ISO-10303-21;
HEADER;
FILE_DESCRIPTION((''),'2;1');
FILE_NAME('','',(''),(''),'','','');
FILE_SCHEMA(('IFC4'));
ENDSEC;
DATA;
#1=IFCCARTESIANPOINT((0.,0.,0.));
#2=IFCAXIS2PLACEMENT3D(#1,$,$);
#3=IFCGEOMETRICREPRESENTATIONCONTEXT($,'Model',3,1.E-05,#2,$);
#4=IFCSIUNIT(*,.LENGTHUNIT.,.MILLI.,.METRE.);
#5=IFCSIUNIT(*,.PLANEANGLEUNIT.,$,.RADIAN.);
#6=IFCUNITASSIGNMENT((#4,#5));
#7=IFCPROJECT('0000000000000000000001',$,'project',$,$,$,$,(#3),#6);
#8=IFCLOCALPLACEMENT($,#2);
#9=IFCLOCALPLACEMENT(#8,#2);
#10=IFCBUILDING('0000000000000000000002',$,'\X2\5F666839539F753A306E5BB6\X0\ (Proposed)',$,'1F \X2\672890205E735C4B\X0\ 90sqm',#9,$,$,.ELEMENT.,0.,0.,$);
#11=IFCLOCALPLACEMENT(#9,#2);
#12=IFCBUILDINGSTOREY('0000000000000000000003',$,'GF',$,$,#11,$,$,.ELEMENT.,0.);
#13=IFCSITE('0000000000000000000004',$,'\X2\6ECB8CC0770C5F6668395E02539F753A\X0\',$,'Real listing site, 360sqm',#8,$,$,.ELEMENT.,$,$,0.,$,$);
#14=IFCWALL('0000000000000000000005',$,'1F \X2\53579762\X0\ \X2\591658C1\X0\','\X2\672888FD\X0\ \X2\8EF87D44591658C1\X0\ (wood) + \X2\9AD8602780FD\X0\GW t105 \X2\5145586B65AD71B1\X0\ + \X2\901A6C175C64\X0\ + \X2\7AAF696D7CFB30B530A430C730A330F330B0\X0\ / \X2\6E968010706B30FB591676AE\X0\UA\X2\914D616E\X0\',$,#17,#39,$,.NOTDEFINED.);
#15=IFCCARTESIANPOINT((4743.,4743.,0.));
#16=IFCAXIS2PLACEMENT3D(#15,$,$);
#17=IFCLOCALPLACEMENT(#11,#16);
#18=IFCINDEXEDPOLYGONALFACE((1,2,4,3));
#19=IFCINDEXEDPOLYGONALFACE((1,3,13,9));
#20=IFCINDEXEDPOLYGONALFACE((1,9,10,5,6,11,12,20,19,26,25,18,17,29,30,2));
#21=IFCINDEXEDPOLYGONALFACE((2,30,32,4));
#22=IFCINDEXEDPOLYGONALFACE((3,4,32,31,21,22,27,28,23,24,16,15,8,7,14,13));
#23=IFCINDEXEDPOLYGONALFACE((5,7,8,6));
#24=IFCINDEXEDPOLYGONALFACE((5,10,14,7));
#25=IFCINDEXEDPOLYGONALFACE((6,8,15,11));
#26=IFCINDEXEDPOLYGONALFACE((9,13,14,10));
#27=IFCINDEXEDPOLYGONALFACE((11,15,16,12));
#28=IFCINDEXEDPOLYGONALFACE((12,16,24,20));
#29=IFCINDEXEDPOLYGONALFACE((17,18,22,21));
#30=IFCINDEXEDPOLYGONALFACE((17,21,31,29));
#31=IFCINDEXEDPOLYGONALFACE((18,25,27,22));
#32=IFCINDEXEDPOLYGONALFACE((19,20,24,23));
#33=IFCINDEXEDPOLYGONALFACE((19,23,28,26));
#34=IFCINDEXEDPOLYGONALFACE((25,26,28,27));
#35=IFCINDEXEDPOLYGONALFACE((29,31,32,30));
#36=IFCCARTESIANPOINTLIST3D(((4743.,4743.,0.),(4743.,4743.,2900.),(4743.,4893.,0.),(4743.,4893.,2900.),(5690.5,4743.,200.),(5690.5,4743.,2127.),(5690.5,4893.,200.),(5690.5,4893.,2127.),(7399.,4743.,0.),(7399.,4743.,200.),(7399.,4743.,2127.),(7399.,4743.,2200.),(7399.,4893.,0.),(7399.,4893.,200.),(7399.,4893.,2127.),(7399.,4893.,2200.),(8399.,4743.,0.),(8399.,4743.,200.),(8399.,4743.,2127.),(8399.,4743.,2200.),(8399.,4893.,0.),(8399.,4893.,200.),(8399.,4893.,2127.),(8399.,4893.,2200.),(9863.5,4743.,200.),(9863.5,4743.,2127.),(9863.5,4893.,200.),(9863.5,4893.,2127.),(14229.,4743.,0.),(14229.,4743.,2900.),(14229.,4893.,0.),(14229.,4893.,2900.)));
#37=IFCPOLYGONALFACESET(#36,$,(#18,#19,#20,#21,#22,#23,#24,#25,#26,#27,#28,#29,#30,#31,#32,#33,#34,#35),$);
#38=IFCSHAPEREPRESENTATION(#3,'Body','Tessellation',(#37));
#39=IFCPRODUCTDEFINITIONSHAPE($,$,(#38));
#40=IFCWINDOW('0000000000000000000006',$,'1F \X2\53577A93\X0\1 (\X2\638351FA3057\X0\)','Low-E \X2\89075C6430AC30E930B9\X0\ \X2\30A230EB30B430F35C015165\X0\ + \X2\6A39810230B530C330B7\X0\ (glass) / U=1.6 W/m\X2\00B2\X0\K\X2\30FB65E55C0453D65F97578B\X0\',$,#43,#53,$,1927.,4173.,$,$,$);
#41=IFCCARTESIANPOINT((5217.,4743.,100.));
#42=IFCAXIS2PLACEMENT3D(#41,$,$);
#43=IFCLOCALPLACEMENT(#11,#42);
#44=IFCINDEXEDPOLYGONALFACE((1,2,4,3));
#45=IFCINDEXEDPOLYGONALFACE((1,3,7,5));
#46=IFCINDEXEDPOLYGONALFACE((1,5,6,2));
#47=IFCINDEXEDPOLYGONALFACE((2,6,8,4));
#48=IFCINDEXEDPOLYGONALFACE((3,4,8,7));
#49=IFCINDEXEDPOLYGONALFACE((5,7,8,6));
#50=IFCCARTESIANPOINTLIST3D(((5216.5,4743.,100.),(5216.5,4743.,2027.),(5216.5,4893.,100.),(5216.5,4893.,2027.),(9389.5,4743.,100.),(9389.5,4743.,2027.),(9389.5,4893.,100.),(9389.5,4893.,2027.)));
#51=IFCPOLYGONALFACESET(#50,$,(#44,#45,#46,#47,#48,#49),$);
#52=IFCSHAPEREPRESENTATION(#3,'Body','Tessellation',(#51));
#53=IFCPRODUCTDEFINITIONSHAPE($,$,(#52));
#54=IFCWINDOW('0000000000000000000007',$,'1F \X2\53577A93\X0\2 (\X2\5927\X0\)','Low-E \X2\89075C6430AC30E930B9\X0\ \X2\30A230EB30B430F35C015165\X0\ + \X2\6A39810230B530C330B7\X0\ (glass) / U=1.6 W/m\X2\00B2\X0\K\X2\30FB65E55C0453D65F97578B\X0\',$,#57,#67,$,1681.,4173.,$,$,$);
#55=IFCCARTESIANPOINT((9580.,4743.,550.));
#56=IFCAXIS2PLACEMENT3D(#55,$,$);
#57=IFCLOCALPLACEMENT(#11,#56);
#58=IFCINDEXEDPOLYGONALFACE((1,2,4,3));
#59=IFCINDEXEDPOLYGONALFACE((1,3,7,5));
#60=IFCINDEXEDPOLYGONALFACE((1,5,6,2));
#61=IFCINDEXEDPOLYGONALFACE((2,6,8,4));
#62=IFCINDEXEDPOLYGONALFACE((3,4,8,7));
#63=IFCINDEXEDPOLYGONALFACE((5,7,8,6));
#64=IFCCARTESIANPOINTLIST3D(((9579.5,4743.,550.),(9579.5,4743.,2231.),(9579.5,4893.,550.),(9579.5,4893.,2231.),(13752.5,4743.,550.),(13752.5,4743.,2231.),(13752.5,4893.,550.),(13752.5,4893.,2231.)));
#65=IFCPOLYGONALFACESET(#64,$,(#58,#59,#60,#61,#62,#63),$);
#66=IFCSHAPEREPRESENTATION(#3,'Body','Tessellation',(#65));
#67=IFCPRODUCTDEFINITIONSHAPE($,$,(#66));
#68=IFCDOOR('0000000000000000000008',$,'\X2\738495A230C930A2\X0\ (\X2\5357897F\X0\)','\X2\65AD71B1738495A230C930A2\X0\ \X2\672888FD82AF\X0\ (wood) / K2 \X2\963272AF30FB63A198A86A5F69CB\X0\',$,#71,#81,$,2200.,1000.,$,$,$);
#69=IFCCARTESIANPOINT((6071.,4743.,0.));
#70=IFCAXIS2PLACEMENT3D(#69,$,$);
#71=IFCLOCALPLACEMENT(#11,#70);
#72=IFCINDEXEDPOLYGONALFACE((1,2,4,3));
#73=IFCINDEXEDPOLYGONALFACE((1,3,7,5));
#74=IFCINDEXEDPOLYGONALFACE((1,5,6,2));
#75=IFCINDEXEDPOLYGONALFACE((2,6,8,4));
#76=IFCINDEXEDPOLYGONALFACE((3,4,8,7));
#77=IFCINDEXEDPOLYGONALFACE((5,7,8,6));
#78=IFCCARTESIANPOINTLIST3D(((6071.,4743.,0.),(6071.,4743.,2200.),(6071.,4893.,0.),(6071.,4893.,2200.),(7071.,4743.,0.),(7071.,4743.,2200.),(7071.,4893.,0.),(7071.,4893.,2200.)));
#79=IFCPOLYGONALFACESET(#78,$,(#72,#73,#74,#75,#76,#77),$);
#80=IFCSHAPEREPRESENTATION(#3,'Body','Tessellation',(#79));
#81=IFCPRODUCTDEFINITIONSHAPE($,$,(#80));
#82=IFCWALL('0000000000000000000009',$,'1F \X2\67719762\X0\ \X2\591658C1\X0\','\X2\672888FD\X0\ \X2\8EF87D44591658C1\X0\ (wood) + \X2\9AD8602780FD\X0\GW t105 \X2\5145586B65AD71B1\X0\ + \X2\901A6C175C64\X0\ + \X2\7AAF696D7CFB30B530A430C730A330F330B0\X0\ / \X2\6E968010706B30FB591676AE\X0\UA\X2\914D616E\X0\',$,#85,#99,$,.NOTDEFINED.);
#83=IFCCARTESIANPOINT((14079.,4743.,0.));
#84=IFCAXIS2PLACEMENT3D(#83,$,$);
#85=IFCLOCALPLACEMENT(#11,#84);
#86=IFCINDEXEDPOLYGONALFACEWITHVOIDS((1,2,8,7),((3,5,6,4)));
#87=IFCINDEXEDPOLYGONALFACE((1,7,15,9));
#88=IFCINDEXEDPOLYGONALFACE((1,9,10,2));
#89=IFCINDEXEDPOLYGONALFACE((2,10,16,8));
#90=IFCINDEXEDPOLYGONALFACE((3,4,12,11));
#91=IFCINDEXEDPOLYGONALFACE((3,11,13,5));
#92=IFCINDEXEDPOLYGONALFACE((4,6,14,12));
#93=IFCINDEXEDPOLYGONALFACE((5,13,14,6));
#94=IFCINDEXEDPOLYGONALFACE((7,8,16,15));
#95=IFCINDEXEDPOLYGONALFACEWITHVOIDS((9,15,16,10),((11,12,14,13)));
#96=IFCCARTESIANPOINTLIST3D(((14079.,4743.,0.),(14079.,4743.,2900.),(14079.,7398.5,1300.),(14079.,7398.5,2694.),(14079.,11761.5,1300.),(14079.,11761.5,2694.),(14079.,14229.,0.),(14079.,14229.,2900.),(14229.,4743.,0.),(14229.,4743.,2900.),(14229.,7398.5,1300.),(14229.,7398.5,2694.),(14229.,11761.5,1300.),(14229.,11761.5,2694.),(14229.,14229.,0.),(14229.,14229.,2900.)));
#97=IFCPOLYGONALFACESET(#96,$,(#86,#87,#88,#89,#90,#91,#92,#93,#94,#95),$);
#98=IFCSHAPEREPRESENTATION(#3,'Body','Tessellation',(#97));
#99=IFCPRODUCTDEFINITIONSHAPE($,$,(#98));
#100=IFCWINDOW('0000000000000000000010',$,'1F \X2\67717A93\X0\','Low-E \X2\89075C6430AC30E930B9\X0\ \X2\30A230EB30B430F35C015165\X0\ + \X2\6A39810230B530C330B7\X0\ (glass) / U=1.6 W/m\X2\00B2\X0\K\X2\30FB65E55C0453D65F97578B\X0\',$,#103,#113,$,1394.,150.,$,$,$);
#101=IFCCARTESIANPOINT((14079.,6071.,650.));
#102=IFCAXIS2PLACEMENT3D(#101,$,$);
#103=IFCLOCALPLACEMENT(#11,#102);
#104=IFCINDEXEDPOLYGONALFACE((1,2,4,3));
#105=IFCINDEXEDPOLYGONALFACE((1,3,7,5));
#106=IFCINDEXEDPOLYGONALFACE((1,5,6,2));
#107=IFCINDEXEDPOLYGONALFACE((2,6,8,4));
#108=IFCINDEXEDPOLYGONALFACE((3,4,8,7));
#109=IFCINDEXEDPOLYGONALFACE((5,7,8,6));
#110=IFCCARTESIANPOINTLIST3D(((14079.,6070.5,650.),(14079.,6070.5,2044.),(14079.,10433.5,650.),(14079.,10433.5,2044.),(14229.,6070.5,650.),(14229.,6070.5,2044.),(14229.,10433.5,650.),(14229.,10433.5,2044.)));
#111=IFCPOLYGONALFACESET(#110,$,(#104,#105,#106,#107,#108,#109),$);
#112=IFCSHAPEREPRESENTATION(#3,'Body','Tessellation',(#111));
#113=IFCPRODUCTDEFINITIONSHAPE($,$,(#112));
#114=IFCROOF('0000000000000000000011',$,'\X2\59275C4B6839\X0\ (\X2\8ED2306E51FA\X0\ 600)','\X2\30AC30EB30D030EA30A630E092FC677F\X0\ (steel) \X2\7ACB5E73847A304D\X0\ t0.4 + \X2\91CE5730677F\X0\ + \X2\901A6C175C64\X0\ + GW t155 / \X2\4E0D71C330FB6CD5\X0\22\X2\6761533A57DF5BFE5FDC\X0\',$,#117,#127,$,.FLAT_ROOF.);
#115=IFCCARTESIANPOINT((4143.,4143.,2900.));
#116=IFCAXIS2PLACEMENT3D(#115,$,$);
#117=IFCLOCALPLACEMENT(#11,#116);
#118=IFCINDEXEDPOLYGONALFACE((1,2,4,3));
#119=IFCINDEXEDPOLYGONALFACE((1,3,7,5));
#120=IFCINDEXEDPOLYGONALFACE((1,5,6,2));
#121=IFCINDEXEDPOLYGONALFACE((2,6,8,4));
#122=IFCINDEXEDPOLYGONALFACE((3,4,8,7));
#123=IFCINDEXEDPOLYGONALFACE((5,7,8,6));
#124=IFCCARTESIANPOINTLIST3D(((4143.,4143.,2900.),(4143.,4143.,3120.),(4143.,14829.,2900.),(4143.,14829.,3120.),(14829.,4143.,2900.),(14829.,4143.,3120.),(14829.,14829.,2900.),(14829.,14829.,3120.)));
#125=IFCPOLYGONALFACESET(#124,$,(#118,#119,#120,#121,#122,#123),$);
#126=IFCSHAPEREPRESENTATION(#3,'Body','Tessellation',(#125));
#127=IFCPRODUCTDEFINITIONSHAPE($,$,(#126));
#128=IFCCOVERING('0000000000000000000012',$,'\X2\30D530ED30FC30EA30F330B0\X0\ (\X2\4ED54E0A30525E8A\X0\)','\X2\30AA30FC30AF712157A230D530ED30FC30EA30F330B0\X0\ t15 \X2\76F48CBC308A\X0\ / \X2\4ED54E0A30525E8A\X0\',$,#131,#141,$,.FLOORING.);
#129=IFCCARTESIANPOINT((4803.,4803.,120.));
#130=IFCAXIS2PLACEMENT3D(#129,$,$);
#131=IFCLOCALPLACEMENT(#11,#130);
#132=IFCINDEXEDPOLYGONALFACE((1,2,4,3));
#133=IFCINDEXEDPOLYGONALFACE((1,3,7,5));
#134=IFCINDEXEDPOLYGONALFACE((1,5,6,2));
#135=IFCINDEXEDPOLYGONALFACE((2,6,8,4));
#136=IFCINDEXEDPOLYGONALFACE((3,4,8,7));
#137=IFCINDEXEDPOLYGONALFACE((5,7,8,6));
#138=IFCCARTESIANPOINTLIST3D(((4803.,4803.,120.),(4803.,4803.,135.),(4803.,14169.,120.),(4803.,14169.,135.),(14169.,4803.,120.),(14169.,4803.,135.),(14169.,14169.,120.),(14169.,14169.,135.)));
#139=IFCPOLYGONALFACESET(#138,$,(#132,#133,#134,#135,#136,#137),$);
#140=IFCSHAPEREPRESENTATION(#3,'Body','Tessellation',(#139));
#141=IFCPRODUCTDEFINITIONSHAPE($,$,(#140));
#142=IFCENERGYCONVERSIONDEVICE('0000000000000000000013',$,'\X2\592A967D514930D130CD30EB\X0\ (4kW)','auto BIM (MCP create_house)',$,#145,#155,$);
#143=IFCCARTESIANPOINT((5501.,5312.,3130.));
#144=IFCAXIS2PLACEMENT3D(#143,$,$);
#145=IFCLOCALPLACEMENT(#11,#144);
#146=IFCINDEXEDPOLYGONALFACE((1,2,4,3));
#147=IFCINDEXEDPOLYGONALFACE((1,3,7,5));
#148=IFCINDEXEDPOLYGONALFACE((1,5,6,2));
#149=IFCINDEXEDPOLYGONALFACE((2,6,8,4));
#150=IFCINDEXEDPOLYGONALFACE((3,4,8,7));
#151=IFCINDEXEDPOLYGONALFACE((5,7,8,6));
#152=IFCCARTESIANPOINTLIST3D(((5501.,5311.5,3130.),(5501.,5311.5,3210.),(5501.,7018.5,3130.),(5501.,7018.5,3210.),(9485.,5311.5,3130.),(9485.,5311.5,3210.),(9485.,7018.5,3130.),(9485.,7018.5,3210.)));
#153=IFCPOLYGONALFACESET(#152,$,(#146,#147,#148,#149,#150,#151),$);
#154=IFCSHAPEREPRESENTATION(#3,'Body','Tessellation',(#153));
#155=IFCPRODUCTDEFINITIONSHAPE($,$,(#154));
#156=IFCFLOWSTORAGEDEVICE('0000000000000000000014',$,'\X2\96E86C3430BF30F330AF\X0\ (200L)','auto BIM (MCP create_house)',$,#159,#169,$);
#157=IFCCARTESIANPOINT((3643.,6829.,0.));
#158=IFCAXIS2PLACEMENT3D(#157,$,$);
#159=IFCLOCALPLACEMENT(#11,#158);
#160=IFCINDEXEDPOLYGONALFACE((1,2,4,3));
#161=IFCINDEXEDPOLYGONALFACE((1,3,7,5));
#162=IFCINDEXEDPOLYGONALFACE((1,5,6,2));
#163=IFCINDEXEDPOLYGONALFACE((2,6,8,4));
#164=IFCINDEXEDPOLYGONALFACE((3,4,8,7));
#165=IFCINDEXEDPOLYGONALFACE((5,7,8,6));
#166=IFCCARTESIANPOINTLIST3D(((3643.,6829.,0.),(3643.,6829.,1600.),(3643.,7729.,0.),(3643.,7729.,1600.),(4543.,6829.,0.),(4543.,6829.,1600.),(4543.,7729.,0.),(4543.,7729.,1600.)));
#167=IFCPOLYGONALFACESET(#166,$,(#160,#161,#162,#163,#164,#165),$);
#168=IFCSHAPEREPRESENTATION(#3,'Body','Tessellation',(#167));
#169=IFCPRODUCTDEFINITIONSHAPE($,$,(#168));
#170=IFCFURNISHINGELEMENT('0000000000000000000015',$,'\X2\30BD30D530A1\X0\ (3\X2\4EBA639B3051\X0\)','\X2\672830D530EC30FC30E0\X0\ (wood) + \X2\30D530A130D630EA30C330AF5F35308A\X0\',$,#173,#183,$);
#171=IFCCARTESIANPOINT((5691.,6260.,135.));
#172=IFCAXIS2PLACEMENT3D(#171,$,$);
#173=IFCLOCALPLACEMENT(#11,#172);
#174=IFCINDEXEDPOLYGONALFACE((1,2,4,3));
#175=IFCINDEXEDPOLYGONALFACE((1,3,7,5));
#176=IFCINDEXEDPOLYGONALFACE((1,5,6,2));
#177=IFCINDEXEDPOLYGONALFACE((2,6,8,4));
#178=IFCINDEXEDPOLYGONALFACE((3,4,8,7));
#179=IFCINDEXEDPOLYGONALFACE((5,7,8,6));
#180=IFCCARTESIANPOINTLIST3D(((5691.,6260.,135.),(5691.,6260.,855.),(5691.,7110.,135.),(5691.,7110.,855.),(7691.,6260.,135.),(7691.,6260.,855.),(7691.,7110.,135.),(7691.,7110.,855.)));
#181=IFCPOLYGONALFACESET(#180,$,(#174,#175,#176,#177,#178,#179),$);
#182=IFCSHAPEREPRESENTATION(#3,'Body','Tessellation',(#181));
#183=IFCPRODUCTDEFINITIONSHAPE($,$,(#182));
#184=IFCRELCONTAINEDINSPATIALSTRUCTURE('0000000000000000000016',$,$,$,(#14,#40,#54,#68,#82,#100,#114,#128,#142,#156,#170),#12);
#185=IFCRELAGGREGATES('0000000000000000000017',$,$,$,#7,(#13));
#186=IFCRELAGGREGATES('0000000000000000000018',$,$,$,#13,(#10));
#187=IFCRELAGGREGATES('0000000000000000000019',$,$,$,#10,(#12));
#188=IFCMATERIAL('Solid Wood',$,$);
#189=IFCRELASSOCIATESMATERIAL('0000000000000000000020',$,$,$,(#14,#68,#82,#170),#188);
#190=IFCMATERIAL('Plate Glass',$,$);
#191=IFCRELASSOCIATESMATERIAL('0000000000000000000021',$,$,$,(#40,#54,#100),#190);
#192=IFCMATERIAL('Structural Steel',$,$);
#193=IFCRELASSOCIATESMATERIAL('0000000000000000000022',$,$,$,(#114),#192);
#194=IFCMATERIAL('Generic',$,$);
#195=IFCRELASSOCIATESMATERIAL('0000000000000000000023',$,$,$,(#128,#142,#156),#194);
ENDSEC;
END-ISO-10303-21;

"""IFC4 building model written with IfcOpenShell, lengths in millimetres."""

from ifc_helpers import new_model, si_unit, frame, frame_2d, origin, place, context, project, spatial, rectangle, extrude, material, element, fill, save


model = new_model("IFC4")

# Units and contexts
model_context = context("Model", 3, precision=1e-05, world=origin())
ifc_project = project(units=[si_unit("LENGTHUNIT", "METRE", prefix="MILLI"), si_unit("PLANEANGLEUNIT", "RADIAN")], contexts=[model_context])

# Site, building, storey
site_placement = place(None, origin())
site = spatial("IfcSite", under=ifc_project, at=site_placement, Name="滋賀県彦根市原町", ObjectType="Real listing site, 360sqm", CompositionType="ELEMENT", RefElevation=0.0)
building_placement = place(site_placement, origin())
building = spatial("IfcBuilding", under=site, at=building_placement, Name="彦根原町の家 (Proposed)", ObjectType="1F 木造平屋 90sqm", CompositionType="ELEMENT", ElevationOfRefHeight=0.0, ElevationOfTerrain=0.0)
storey_placement = place(building_placement, origin())
storey = spatial("IfcBuildingStorey", under=building, at=storey_placement, Name="GF", CompositionType="ELEMENT", Elevation=0.0)

# Shared definitions
ifc_material_1 = material(Name="Solid Wood")

# Wall, openings, windows, door
wall_1_placement = place(storey_placement, frame((4743.0, 4743.0, 0.0)))
wall_1 = element("IfcWall", 1, at=wall_1_placement, inside=storey, material=ifc_material_1, Name="1F 南面 外壁", Description="木製 軸組外壁 (wood) + 高性能GW t105 充填断熱 + 通気層 + 窯業系サイディング / 準耐火・外皮UA配慮", PredefinedType="NOTDEFINED", context=model_context, shape_type="SweptSolid", body=[
    extrude(rectangle(XDim=9486.0, YDim=150.0, at=frame_2d((4743.0, 75.0))), frame((4743.0, 4743.0, 0.0)), (0.0, 0.0, 1.0), 2900.0),
])
opening_1_placement = place(storey_placement, frame((5217.0, 4743.0, 100.0)))
opening_1 = element("IfcOpeningElement", 2, at=opening_1_placement, cuts=wall_1, PredefinedType="NOTDEFINED", context=model_context, shape_type="SweptSolid", body=[
    extrude(rectangle(XDim=4173.0, YDim=150.0, at=frame_2d((2086.0, 75.0))), frame((5217.0, 4743.0, 100.0)), (0.0, 0.0, 1.0), 1927.0),
])
opening_2_placement = place(storey_placement, frame((9580.0, 4743.0, 550.0)))
opening_2 = element("IfcOpeningElement", 3, at=opening_2_placement, cuts=wall_1, PredefinedType="NOTDEFINED", context=model_context, shape_type="SweptSolid", body=[
    extrude(rectangle(XDim=4173.0, YDim=150.0, at=frame_2d((2086.0, 75.0))), frame((9580.0, 4743.0, 550.0)), (0.0, 0.0, 1.0), 1681.0),
])
opening_3_placement = place(storey_placement, frame((6071.0, 4743.0, 0.0)))
opening_3 = element("IfcOpeningElement", 4, at=opening_3_placement, cuts=wall_1, PredefinedType="NOTDEFINED", context=model_context, shape_type="SweptSolid", body=[
    extrude(rectangle(XDim=1000.0, YDim=150.0, at=frame_2d((500.0, 75.0))), frame((6071.0, 4743.0, 0.0)), (0.0, 0.0, 1.0), 2200.0),
])
ifc_material_2 = material(Name="Plate Glass")
window_1_placement = place(storey_placement, frame((5217.0, 4743.0, 100.0)))
window_1 = element("IfcWindow", 5, at=window_1_placement, inside=storey, material=ifc_material_2, Name="1F 南窓1 (掃出し)", Description="Low-E 複層ガラス アルゴン封入 + 樹脂サッシ (glass) / U=1.6 W/m²K・日射取得型", OverallHeight=1927.0, OverallWidth=4173.0, context=model_context, shape_type="SweptSolid", body=[
    extrude(rectangle(XDim=4173.0, YDim=150.0, at=frame_2d((2086.0, 75.0))), frame((5217.0, 4743.0, 100.0)), (0.0, 0.0, 1.0), 1927.0),
])
fill(opening_1, window_1)
window_2_placement = place(storey_placement, frame((9580.0, 4743.0, 550.0)))
window_2 = element("IfcWindow", 6, at=window_2_placement, inside=storey, material=ifc_material_2, Name="1F 南窓2 (大)", Description="Low-E 複層ガラス アルゴン封入 + 樹脂サッシ (glass) / U=1.6 W/m²K・日射取得型", OverallHeight=1681.0, OverallWidth=4173.0, context=model_context, shape_type="SweptSolid", body=[
    extrude(rectangle(XDim=4173.0, YDim=150.0, at=frame_2d((2086.0, 75.0))), frame((9580.0, 4743.0, 550.0)), (0.0, 0.0, 1.0), 1681.0),
])
fill(opening_2, window_2)
door_placement = place(storey_placement, frame((6071.0, 4743.0, 0.0)))
door = element("IfcDoor", 7, at=door_placement, inside=storey, material=ifc_material_1, Name="玄関ドア (南西)", Description="断熱玄関ドア 木製芯 (wood) / K2 防犯・採風機構", OverallHeight=2200.0, OverallWidth=1000.0, context=model_context, shape_type="SweptSolid", body=[
    extrude(rectangle(XDim=1000.0, YDim=150.0, at=frame_2d((500.0, 75.0))), frame((6071.0, 4743.0, 0.0)), (0.0, 0.0, 1.0), 2200.0),
])
fill(opening_3, door)

# Wall, opening, window
wall_2_placement = place(storey_placement, frame((14079.0, 4743.0, 0.0)))
wall_2 = element("IfcWall", 8, at=wall_2_placement, inside=storey, material=ifc_material_1, Name="1F 東面 外壁", Description="木製 軸組外壁 (wood) + 高性能GW t105 充填断熱 + 通気層 + 窯業系サイディング / 準耐火・外皮UA配慮", PredefinedType="NOTDEFINED", context=model_context, shape_type="SweptSolid", body=[
    extrude(rectangle(XDim=150.0, YDim=9486.0, at=frame_2d((75.0, 4743.0))), frame((14079.0, 4743.0, 0.0)), (0.0, 0.0, 1.0), 2900.0),
])
opening_4_placement = place(storey_placement, frame((14079.0, 6071.0, 650.0)))
opening_4 = element("IfcOpeningElement", 9, at=opening_4_placement, cuts=wall_2, PredefinedType="NOTDEFINED", context=model_context, shape_type="SweptSolid", body=[
    extrude(rectangle(XDim=150.0, YDim=4363.0, at=frame_2d((75.0, 2181.0))), frame((14079.0, 6071.0, 650.0)), (0.0, 0.0, 1.0), 1394.0),
])
window_3_placement = place(storey_placement, frame((14079.0, 6071.0, 650.0)))
window_3 = element("IfcWindow", 10, at=window_3_placement, inside=storey, material=ifc_material_2, Name="1F 東窓", Description="Low-E 複層ガラス アルゴン封入 + 樹脂サッシ (glass) / U=1.6 W/m²K・日射取得型", OverallHeight=1394.0, OverallWidth=150.0, context=model_context, shape_type="SweptSolid", body=[
    extrude(rectangle(XDim=150.0, YDim=4363.0, at=frame_2d((75.0, 2181.0))), frame((14079.0, 6071.0, 650.0)), (0.0, 0.0, 1.0), 1394.0),
])
fill(opening_4, window_3)

# Roof
ifc_material_3 = material(Name="Structural Steel")
roof_placement = place(storey_placement, frame((4143.0, 4143.0, 2900.0)))
element("IfcRoof", 11, at=roof_placement, inside=storey, material=ifc_material_3, Name="大屋根 (軒の出 600)", Description="ガルバリウム鋼板 (steel) 立平葺き t0.4 + 野地板 + 通気層 + GW t155 / 不燃・法22条区域対応", PredefinedType="FLAT_ROOF", context=model_context, shape_type="SweptSolid", body=[
    extrude(rectangle(XDim=10686.0, YDim=10686.0, at=frame_2d((5343.0, 5343.0))), frame((4143.0, 4143.0, 2900.0)), (0.0, 0.0, 1.0), 220.0),
])

# Covering
ifc_material_4 = material(Name="Generic")
covering_placement = place(storey_placement, frame((4803.0, 4803.0, 120.0)))
element("IfcCovering", 12, at=covering_placement, inside=storey, material=ifc_material_4, Name="フローリング (仕上げ床)", Description="オーク無垢フローリング t15 直貼り / 仕上げ床", PredefinedType="FLOORING", context=model_context, shape_type="SweptSolid", body=[
    extrude(rectangle(XDim=9366.0, YDim=9366.0, at=frame_2d((4683.0, 4683.0))), frame((4803.0, 4803.0, 120.0)), (0.0, 0.0, 1.0), 15.0),
])

# Energy conversion device
energy_conversion_device_placement = place(storey_placement, frame((5501.0, 5312.0, 3130.0)))
element("IfcEnergyConversionDevice", 13, at=energy_conversion_device_placement, inside=storey, material=ifc_material_4, Name="太陽光パネル (4kW)", Description="auto BIM (MCP create_house)", context=model_context, shape_type="SweptSolid", body=[
    extrude(rectangle(XDim=3984.0, YDim=1707.0, at=frame_2d((1992.0, 853.0))), frame((5501.0, 5312.0, 3130.0)), (0.0, 0.0, 1.0), 80.0),
])

# Flow storage device
flow_storage_device_placement = place(storey_placement, frame((3643.0, 6829.0, 0.0)))
element("IfcFlowStorageDevice", 14, at=flow_storage_device_placement, inside=storey, material=ifc_material_4, Name="雨水タンク (200L)", Description="auto BIM (MCP create_house)", context=model_context, shape_type="SweptSolid", body=[
    extrude(rectangle(XDim=900.0, YDim=900.0, at=frame_2d((450.0, 450.0))), frame((3643.0, 6829.0, 0.0)), (0.0, 0.0, 1.0), 1600.0),
])

# Furnishing element
furnishing_1_placement = place(storey_placement, frame((5691.0, 6260.0, 135.0)))
element("IfcFurnishingElement", 15, at=furnishing_1_placement, inside=storey, material=ifc_material_1, Name="ソファ (3人掛け)", Description="木フレーム (wood) + ファブリック張り", context=model_context, shape_type="SweptSolid", body=[
    extrude(rectangle(XDim=2000.0, YDim=850.0, at=frame_2d((1000.0, 425.0))), frame((5691.0, 6260.0, 135.0)), (0.0, 0.0, 1.0), 720.0),
])

save(model, "model.ifc")
